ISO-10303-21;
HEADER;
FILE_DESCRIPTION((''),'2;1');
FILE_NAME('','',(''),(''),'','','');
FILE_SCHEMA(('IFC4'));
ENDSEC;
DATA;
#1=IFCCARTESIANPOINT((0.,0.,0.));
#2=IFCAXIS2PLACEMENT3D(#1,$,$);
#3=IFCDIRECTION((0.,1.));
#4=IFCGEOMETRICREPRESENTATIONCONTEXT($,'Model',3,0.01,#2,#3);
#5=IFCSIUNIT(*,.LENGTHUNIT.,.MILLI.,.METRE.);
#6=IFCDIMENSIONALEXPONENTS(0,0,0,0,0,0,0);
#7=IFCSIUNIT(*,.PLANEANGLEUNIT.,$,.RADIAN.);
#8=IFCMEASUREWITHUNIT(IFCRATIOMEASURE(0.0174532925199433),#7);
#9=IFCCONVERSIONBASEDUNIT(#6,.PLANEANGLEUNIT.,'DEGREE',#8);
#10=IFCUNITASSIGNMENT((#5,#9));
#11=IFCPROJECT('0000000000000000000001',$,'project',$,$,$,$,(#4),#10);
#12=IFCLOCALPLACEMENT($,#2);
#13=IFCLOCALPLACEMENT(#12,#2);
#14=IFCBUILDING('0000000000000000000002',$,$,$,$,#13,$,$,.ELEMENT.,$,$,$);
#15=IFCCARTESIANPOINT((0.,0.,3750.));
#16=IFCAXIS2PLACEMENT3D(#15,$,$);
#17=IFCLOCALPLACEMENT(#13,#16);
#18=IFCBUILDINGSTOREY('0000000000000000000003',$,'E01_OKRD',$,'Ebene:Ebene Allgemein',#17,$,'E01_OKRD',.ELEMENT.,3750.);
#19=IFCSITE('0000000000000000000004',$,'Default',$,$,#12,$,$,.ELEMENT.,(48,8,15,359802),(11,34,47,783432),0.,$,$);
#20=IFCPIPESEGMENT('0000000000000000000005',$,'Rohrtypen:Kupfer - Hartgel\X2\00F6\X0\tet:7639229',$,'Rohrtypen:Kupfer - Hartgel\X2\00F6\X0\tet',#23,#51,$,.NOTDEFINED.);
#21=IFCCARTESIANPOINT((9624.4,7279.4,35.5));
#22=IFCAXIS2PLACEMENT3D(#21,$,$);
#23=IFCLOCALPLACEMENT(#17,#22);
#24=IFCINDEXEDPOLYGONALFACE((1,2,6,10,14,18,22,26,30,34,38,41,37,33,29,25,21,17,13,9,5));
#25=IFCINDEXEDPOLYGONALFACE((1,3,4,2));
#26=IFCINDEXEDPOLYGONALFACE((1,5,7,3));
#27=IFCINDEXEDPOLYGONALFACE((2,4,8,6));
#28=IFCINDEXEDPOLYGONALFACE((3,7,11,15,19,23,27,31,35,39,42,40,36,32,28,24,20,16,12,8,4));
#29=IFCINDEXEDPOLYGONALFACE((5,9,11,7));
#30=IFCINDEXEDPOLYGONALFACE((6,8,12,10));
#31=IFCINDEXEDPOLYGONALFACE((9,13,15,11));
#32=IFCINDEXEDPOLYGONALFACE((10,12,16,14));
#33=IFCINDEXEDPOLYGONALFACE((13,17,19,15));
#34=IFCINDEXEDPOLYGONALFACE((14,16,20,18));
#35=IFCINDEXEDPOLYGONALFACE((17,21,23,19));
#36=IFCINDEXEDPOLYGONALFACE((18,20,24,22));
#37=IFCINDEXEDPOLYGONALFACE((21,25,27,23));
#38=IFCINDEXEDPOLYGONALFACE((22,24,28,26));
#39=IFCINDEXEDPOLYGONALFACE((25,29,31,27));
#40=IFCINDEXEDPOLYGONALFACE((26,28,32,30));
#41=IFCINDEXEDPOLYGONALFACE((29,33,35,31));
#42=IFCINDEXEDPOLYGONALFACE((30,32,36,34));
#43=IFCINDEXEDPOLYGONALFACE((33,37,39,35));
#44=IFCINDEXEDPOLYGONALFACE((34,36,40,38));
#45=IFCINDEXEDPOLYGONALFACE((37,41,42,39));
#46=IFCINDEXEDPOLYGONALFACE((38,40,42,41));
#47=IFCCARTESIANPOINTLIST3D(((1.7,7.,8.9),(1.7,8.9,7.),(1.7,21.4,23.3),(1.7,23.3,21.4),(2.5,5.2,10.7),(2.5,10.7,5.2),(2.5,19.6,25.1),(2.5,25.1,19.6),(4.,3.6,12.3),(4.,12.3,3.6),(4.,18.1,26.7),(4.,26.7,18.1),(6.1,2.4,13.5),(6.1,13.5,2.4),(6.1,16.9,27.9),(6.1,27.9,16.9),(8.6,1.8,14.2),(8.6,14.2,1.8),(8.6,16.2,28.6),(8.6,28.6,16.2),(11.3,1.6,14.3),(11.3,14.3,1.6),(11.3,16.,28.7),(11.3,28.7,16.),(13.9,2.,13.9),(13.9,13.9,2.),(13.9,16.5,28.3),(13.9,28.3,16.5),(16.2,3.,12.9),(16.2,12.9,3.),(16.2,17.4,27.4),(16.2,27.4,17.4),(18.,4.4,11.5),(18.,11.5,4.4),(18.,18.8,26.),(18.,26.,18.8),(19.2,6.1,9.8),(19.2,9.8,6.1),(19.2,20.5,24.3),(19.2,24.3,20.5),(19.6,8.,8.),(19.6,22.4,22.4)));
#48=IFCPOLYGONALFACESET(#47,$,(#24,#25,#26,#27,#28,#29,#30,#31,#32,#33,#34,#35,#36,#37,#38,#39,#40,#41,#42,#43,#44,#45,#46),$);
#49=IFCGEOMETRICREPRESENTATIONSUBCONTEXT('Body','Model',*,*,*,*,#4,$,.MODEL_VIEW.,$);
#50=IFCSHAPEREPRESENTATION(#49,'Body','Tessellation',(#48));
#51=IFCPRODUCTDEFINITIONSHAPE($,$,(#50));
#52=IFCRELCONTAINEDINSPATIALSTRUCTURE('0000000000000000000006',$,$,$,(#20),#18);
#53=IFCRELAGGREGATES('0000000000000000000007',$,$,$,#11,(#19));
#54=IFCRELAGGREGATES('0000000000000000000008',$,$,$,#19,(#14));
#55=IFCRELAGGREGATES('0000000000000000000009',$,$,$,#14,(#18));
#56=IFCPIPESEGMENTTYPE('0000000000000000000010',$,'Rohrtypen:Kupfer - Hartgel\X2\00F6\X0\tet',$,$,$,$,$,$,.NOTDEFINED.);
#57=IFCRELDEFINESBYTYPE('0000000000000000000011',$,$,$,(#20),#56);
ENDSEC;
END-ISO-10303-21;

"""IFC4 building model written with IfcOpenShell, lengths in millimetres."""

from ifc_helpers import new_model, entity, si_unit, converted_unit, direction, frame, origin, origin_2d_with_axis, place, context, subcontext, project, spatial, circle, extrude, type_object, element, save


model = new_model("IFC4")

# Units and contexts
model_context = context("Model", 3, precision=0.01, world=origin(), true_north=direction((0.0, 1.0)))
body_context = subcontext(model_context, "Body", "Model", "MODEL_VIEW")
ifc_project = project(units=[si_unit("LENGTHUNIT", "METRE", prefix="MILLI"), converted_unit("PLANEANGLEUNIT", "DEGREE", entity("IfcRatioMeasure", 0.0174532925199433), si_unit("PLANEANGLEUNIT", "RADIAN"), dimensions=[0, 0, 0, 0, 0, 0, 0])], contexts=[model_context])

# Site, building, storey
site_placement = place(None, origin())
site = spatial("IfcSite", under=ifc_project, at=site_placement, Name="Default", CompositionType="ELEMENT", RefLatitude=(48, 8, 15, 359802), RefLongitude=(11, 34, 47, 783432), RefElevation=0.0)
building_placement = place(site_placement, origin())
building = spatial("IfcBuilding", under=site, at=building_placement, CompositionType="ELEMENT")
storey_placement = place(building_placement, frame((0.0, 0.0, 3750.0)))
storey = spatial("IfcBuildingStorey", under=building, at=storey_placement, Name="E01_OKRD", ObjectType="Ebene:Ebene Allgemein", LongName="E01_OKRD", CompositionType="ELEMENT", Elevation=3750.0)

# Pipe segment
pipe_segment_type = type_object("IfcPipeSegmentType", Name="Rohrtypen:Kupfer - Hartgelötet", PredefinedType="NOTDEFINED")
pipe_segment_1_placement = place(storey_placement, frame((9624.4, 7279.4, 35.5)))
element("IfcPipeSegment", 1, at=pipe_segment_1_placement, inside=storey, type_object=pipe_segment_type, Name="Rohrtypen:Kupfer - Hartgelötet:7639229", ObjectType="Rohrtypen:Kupfer - Hartgelötet", PredefinedType="NOTDEFINED", context=body_context, shape_type="SweptSolid", body=[
    extrude(circle(Radius=9.0, at=origin_2d_with_axis()), frame((10.6, 8.0, 8.0), z_axis=(0.0, 0.707107, 0.707107), x_axis=(1.0, 0.0, 0.0)), (0.0, 0.0, 1.0), 20.4),
])

save(model, "model.ifc")
